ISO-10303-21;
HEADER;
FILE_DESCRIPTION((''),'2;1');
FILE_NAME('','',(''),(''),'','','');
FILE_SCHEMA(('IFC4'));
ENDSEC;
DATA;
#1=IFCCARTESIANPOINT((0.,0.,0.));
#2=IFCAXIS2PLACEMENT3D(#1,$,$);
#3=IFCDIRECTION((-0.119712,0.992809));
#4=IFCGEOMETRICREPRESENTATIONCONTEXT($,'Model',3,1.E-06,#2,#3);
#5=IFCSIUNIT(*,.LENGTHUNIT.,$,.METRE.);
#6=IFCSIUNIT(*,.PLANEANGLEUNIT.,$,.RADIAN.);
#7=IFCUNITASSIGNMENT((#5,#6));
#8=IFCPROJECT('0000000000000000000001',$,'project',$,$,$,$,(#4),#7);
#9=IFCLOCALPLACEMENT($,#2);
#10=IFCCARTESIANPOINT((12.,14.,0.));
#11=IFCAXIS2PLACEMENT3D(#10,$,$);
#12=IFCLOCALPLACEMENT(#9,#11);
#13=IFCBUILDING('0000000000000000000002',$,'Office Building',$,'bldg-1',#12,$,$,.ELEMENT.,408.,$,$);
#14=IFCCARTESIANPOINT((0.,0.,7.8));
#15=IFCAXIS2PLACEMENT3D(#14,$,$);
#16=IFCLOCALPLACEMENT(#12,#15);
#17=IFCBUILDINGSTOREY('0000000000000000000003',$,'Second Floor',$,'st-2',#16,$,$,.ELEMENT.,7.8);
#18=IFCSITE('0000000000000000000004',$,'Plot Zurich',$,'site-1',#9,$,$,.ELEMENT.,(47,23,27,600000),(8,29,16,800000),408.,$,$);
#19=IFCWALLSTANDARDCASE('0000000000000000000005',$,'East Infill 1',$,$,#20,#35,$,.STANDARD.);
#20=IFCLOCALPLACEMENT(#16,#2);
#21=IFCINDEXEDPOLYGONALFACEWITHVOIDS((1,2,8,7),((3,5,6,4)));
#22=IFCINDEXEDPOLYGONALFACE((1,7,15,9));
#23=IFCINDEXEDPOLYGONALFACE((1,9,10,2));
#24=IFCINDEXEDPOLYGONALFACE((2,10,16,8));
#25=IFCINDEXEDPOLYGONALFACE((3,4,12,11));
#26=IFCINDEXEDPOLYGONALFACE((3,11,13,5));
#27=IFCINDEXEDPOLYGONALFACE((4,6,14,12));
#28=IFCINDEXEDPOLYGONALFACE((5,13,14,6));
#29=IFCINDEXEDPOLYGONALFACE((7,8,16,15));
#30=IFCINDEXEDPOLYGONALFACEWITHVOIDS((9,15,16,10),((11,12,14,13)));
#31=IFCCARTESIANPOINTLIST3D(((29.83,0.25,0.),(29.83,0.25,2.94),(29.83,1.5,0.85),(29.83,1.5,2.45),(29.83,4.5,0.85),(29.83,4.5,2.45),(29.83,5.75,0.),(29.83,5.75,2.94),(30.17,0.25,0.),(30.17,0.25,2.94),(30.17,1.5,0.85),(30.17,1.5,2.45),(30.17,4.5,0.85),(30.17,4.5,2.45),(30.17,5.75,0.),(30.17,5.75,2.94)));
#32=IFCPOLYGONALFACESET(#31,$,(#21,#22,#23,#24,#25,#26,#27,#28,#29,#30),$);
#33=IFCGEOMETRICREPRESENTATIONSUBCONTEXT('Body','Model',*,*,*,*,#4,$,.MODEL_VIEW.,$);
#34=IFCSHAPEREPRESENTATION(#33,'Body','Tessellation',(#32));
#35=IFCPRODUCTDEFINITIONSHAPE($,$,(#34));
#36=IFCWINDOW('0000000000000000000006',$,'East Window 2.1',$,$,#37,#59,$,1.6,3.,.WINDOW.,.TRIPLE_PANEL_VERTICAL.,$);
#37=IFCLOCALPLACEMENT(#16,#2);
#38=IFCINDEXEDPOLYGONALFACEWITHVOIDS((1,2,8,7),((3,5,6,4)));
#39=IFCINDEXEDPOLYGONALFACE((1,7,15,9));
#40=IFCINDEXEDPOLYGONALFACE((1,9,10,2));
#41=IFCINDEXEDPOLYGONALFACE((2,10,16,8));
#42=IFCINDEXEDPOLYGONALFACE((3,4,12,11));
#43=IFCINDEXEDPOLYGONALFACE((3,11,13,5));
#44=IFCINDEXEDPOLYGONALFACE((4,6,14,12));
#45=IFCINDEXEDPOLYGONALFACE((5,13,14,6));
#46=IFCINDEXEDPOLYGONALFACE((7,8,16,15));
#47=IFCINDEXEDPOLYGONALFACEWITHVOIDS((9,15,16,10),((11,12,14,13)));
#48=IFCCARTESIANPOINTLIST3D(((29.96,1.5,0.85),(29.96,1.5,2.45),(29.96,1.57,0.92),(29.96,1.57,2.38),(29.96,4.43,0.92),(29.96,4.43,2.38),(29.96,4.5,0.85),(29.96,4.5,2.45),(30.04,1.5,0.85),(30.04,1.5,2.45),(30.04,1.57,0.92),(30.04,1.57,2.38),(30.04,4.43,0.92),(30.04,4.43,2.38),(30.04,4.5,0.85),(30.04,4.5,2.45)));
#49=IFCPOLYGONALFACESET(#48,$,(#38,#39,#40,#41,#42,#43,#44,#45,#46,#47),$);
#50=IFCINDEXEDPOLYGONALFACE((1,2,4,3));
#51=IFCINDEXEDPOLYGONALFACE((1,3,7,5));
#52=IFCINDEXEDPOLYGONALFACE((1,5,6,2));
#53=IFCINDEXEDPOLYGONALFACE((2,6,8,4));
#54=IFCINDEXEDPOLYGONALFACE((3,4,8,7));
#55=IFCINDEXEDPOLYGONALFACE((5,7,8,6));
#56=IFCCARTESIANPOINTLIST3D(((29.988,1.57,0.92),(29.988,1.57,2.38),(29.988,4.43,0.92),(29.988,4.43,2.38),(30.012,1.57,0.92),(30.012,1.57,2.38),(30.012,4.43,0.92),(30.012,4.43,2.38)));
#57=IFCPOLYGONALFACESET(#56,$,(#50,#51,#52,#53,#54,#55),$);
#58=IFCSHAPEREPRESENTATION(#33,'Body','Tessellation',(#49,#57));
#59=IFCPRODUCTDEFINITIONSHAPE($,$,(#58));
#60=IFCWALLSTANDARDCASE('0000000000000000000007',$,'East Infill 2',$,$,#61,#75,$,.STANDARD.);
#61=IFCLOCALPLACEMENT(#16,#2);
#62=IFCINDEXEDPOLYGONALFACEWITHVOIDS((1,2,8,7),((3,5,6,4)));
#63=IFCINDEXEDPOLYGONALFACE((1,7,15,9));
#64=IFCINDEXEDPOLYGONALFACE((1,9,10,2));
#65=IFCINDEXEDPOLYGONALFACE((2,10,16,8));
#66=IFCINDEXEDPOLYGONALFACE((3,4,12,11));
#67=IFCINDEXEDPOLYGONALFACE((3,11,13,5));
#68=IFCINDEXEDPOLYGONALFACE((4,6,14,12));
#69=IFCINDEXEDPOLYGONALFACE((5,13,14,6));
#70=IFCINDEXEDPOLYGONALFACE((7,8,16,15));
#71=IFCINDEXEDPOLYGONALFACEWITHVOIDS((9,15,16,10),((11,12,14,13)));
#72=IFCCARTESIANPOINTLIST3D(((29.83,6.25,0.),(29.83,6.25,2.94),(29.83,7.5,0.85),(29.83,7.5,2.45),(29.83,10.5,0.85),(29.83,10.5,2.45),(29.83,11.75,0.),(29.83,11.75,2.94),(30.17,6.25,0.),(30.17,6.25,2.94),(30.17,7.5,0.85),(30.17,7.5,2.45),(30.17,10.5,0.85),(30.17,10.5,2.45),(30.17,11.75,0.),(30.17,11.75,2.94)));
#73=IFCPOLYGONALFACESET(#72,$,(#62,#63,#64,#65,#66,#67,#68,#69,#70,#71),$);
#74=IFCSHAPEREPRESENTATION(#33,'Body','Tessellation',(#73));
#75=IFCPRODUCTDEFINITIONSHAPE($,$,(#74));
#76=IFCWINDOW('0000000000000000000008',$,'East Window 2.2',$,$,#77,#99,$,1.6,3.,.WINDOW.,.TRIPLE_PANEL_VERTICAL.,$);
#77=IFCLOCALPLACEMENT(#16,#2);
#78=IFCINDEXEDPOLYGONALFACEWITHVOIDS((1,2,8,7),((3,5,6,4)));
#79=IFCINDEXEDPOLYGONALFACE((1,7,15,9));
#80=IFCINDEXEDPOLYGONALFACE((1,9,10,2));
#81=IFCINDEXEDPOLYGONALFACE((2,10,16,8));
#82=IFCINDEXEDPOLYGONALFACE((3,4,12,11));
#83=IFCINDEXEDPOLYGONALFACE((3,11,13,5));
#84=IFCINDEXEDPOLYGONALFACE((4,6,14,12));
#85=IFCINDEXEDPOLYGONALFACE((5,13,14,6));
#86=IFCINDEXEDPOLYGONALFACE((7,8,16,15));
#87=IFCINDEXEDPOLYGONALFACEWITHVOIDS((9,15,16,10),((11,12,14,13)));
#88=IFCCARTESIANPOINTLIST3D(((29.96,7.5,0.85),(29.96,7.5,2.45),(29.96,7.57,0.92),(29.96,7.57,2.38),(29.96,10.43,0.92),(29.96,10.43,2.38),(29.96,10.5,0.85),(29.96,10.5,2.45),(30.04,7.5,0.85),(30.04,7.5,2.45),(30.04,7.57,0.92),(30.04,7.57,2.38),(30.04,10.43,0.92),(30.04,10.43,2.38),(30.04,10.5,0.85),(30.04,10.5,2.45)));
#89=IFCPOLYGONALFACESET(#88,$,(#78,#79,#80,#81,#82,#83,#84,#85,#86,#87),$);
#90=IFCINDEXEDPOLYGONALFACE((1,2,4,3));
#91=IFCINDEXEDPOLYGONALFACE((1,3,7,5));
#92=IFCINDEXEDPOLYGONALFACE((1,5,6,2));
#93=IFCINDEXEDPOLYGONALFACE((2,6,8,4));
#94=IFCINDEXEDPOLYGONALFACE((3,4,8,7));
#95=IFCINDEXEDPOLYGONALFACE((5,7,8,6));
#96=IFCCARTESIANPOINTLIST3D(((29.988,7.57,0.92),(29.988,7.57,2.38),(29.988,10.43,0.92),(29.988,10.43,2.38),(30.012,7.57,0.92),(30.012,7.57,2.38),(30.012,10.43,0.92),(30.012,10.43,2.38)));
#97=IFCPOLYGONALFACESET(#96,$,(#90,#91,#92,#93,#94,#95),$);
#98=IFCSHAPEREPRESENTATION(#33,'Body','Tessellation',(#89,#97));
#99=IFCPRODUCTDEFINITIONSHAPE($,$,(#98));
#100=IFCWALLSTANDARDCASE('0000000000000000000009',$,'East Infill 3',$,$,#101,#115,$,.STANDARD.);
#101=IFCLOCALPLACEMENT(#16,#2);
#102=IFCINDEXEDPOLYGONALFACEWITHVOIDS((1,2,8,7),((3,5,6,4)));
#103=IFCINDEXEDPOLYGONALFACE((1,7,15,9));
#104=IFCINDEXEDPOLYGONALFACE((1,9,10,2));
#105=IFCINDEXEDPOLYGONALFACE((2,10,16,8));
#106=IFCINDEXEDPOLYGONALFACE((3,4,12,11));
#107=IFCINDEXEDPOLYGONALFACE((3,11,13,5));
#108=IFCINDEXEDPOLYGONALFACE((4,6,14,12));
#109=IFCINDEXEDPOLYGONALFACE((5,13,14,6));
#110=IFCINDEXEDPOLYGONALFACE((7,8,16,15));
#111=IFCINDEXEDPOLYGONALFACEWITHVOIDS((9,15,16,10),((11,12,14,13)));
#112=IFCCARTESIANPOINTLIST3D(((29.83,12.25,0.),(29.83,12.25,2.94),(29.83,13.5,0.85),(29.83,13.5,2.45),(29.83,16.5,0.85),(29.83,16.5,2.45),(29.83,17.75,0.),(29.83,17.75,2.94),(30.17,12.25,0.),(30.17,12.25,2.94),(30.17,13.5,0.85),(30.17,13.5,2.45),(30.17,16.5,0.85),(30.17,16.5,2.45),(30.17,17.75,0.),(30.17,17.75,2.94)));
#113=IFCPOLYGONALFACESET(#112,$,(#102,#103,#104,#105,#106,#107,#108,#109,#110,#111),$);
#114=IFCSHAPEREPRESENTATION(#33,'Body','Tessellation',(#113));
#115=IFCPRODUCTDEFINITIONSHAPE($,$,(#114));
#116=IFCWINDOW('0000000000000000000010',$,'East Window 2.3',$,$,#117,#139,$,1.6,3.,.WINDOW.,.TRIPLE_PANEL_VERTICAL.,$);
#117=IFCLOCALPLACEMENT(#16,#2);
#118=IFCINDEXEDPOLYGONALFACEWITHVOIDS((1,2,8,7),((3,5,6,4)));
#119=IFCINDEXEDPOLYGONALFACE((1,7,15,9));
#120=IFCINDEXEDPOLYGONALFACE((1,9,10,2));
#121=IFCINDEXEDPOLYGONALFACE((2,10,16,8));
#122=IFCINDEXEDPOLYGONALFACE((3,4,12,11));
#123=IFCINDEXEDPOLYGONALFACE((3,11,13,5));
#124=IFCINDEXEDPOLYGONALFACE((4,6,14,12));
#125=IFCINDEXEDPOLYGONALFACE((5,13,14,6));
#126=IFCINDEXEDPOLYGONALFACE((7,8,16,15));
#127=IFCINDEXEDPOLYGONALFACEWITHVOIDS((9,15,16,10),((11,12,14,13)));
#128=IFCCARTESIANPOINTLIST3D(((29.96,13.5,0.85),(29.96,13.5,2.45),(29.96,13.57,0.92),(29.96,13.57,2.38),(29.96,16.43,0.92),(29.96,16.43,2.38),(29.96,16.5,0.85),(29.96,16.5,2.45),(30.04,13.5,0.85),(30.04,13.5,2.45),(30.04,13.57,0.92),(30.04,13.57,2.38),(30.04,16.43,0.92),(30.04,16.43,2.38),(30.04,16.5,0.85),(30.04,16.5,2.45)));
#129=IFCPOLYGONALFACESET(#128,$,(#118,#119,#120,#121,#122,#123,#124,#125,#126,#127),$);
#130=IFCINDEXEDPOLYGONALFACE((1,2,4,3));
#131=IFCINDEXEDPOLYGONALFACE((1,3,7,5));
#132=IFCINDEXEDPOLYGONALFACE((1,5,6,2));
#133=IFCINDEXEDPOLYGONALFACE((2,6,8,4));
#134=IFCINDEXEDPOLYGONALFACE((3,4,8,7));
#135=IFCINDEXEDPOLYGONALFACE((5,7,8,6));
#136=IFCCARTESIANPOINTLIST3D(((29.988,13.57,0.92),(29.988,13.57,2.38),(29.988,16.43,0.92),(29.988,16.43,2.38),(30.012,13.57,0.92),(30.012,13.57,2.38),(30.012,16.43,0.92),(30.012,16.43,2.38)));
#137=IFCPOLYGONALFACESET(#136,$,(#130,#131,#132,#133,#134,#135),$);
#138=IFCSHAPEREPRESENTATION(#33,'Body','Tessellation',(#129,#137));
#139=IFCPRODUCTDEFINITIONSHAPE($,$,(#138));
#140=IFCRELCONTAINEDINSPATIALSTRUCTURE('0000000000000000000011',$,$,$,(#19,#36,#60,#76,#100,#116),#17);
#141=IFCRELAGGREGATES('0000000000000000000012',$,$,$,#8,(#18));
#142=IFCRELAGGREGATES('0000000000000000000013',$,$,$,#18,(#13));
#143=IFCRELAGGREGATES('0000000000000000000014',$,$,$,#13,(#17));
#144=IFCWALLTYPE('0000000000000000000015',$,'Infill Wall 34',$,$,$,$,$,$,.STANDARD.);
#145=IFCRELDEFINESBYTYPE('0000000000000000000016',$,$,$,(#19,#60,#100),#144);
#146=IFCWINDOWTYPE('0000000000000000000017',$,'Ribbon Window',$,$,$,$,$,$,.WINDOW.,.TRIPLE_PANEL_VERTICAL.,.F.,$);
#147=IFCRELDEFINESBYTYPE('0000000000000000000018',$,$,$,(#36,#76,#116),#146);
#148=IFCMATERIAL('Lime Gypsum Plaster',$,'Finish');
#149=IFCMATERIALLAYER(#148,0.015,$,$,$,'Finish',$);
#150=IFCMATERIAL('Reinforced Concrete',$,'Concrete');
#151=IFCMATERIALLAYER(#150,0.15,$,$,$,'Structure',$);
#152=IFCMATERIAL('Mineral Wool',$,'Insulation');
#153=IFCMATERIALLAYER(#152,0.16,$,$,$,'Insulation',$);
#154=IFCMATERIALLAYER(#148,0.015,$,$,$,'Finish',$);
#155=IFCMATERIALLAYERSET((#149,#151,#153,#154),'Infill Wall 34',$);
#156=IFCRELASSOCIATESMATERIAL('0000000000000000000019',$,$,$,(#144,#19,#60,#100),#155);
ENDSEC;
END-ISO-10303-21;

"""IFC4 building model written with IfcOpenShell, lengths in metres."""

from ifc_helpers import new_model, si_unit, direction, frame, frame_2d, origin, origin_2d, place, context, subcontext, project, spatial, polyline, rectangle, outline, extrude, material, layer, layer_set, layer_usage, type_object, element, fill, save


model = new_model("IFC4")

# Units and contexts
model_context = context("Model", 3, precision=1e-06, world=origin(), true_north=direction((-0.119712, 0.992809)))
body_context = subcontext(model_context, "Body", "Model", "MODEL_VIEW")
ifc_project = project(units=[si_unit("LENGTHUNIT", "METRE"), si_unit("PLANEANGLEUNIT", "RADIAN")], contexts=[model_context])

# Site, building, storey
site_placement = place(None, origin())
site = spatial("IfcSite", under=ifc_project, at=site_placement, Name="Plot Zurich", ObjectType="site-1", CompositionType="ELEMENT", RefLatitude=(47, 23, 27, 600000), RefLongitude=(8, 29, 16, 800000), RefElevation=408.0)
building_placement = place(site_placement, frame((12.0, 14.0, 0.0)))
building = spatial("IfcBuilding", under=site, at=building_placement, Name="Office Building", ObjectType="bldg-1", CompositionType="ELEMENT", ElevationOfRefHeight=408.0)
storey_placement = place(building_placement, frame((0.0, 0.0, 7.8)))
storey = spatial("IfcBuildingStorey", under=building, at=storey_placement, Name="Second Floor", ObjectType="st-2", CompositionType="ELEMENT", Elevation=7.8)

# Shared definitions
ifc_material_1 = material(Name="Reinforced Concrete", Category="Concrete")

# Walls, openings, windows
ifc_material_2 = material(Name="Lime Gypsum Plaster", Category="Finish")
ifc_layer_1 = layer(ifc_material_2, 0.015, Category="Finish")
ifc_layer_2 = layer(ifc_material_1, 0.15, Category="Structure")
ifc_material_3 = material(Name="Mineral Wool", Category="Insulation")
ifc_layer_3 = layer(ifc_material_3, 0.16, Category="Insulation")
ifc_layer_4 = layer(ifc_material_2, 0.015, Category="Finish")
ifc_layer_set = layer_set([ifc_layer_1, ifc_layer_2, ifc_layer_3, ifc_layer_4], Name="Infill Wall 34")
ifc_layer_usage_1 = layer_usage(ifc_layer_set, "AXIS2", "NEGATIVE", 0.17)
wall_type = type_object("IfcWallType", Name="Infill Wall 34", PredefinedType="STANDARD", material=ifc_layer_set)
wall_1_placement = place(storey_placement, frame((30.0, 0.25, 0.0), z_axis=(0.0, 0.0, 1.0), x_axis=(0.0, 1.0, 0.0)))
wall_1 = element("IfcWallStandardCase", 1, at=wall_1_placement, inside=storey, type_object=wall_type, material=ifc_layer_usage_1, Name="East Infill 1", PredefinedType="STANDARD", context=body_context, shape_type="SweptSolid", body=[
    extrude(rectangle(XDim=5.5, YDim=0.34, at=frame_2d((2.75, 0.0))), origin(), (0.0, 0.0, 1.0), 2.94),
])
opening_1_placement = place(wall_1_placement, frame((2.75, 0.0, 0.85)))
opening_1 = element("IfcOpeningElement", 2, at=opening_1_placement, cuts=wall_1, PredefinedType="OPENING", context=body_context, shape_type="SweptSolid", body=[
    extrude(rectangle(XDim=3.0, YDim=0.34, at=origin_2d()), origin(), (0.0, 0.0, 1.0), 1.6),
])
window_type = type_object("IfcWindowType", Name="Ribbon Window", ParameterTakesPrecedence=False, PartitioningType="TRIPLE_PANEL_VERTICAL", PredefinedType="WINDOW")
window_1_placement = place(opening_1_placement, frame((0.0, 0.0, 0.0), z_axis=(0.0, 1.0, 0.0), x_axis=(-1.0, 0.0, 0.0)))
window_1 = element("IfcWindow", 3, at=window_1_placement, inside=storey, type_object=window_type, Name="East Window 2.1", OverallHeight=1.6, OverallWidth=3.0, PartitioningType="TRIPLE_PANEL_VERTICAL", PredefinedType="WINDOW", context=body_context, shape_type="SweptSolid", body=[
    extrude(outline(polyline([(-1.5, 0.0), (1.5, 0.0), (1.5, 1.6), (-1.5, 1.6), (-1.5, 0.0)]), holes=[polyline([(-1.43, 0.07), (1.43, 0.07), (1.43, 1.53), (-1.43, 1.53), (-1.43, 0.07)])]), frame((0.0, 0.0, -0.04)), (0.0, 0.0, 1.0), 0.08),
    extrude(rectangle(XDim=2.86, YDim=1.46, at=frame_2d((0.0, 0.8))), frame((0.0, 0.0, -0.012)), (0.0, 0.0, 1.0), 0.024),
])
fill(opening_1, window_1)
ifc_layer_usage_2 = layer_usage(ifc_layer_set, "AXIS2", "NEGATIVE", 0.17)
wall_2_placement = place(storey_placement, frame((30.0, 6.25, 0.0), z_axis=(0.0, 0.0, 1.0), x_axis=(0.0, 1.0, 0.0)))
wall_2 = element("IfcWallStandardCase", 4, at=wall_2_placement, inside=storey, type_object=wall_type, material=ifc_layer_usage_2, Name="East Infill 2", PredefinedType="STANDARD", context=body_context, shape_type="SweptSolid", body=[
    extrude(rectangle(XDim=5.5, YDim=0.34, at=frame_2d((2.75, 0.0))), origin(), (0.0, 0.0, 1.0), 2.94),
])
opening_2_placement = place(wall_2_placement, frame((2.75, 0.0, 0.85)))
opening_2 = element("IfcOpeningElement", 5, at=opening_2_placement, cuts=wall_2, PredefinedType="OPENING", context=body_context, shape_type="SweptSolid", body=[
    extrude(rectangle(XDim=3.0, YDim=0.34, at=origin_2d()), origin(), (0.0, 0.0, 1.0), 1.6),
])
window_2_placement = place(opening_2_placement, frame((0.0, 0.0, 0.0), z_axis=(0.0, 1.0, 0.0), x_axis=(-1.0, 0.0, 0.0)))
window_2 = element("IfcWindow", 6, at=window_2_placement, inside=storey, type_object=window_type, Name="East Window 2.2", OverallHeight=1.6, OverallWidth=3.0, PartitioningType="TRIPLE_PANEL_VERTICAL", PredefinedType="WINDOW", context=body_context, shape_type="SweptSolid", body=[
    extrude(outline(polyline([(-1.5, 0.0), (1.5, 0.0), (1.5, 1.6), (-1.5, 1.6), (-1.5, 0.0)]), holes=[polyline([(-1.43, 0.07), (1.43, 0.07), (1.43, 1.53), (-1.43, 1.53), (-1.43, 0.07)])]), frame((0.0, 0.0, -0.04)), (0.0, 0.0, 1.0), 0.08),
    extrude(rectangle(XDim=2.86, YDim=1.46, at=frame_2d((0.0, 0.8))), frame((0.0, 0.0, -0.012)), (0.0, 0.0, 1.0), 0.024),
])
fill(opening_2, window_2)
ifc_layer_usage_3 = layer_usage(ifc_layer_set, "AXIS2", "NEGATIVE", 0.17)
wall_3_placement = place(storey_placement, frame((30.0, 12.25, 0.0), z_axis=(0.0, 0.0, 1.0), x_axis=(0.0, 1.0, 0.0)))
wall_3 = element("IfcWallStandardCase", 7, at=wall_3_placement, inside=storey, type_object=wall_type, material=ifc_layer_usage_3, Name="East Infill 3", PredefinedType="STANDARD", context=body_context, shape_type="SweptSolid", body=[
    extrude(rectangle(XDim=5.5, YDim=0.34, at=frame_2d((2.75, 0.0))), origin(), (0.0, 0.0, 1.0), 2.94),
])
opening_3_placement = place(wall_3_placement, frame((2.75, 0.0, 0.85)))
opening_3 = element("IfcOpeningElement", 8, at=opening_3_placement, cuts=wall_3, PredefinedType="OPENING", context=body_context, shape_type="SweptSolid", body=[
    extrude(rectangle(XDim=3.0, YDim=0.34, at=origin_2d()), origin(), (0.0, 0.0, 1.0), 1.6),
])
window_3_placement = place(opening_3_placement, frame((0.0, 0.0, 0.0), z_axis=(0.0, 1.0, 0.0), x_axis=(-1.0, 0.0, 0.0)))
window_3 = element("IfcWindow", 9, at=window_3_placement, inside=storey, type_object=window_type, Name="East Window 2.3", OverallHeight=1.6, OverallWidth=3.0, PartitioningType="TRIPLE_PANEL_VERTICAL", PredefinedType="WINDOW", context=body_context, shape_type="SweptSolid", body=[
    extrude(outline(polyline([(-1.5, 0.0), (1.5, 0.0), (1.5, 1.6), (-1.5, 1.6), (-1.5, 0.0)]), holes=[polyline([(-1.43, 0.07), (1.43, 0.07), (1.43, 1.53), (-1.43, 1.53), (-1.43, 0.07)])]), frame((0.0, 0.0, -0.04)), (0.0, 0.0, 1.0), 0.08),
    extrude(rectangle(XDim=2.86, YDim=1.46, at=frame_2d((0.0, 0.8))), frame((0.0, 0.0, -0.012)), (0.0, 0.0, 1.0), 0.024),
])
fill(opening_3, window_3)

save(model, "model.ifc")
